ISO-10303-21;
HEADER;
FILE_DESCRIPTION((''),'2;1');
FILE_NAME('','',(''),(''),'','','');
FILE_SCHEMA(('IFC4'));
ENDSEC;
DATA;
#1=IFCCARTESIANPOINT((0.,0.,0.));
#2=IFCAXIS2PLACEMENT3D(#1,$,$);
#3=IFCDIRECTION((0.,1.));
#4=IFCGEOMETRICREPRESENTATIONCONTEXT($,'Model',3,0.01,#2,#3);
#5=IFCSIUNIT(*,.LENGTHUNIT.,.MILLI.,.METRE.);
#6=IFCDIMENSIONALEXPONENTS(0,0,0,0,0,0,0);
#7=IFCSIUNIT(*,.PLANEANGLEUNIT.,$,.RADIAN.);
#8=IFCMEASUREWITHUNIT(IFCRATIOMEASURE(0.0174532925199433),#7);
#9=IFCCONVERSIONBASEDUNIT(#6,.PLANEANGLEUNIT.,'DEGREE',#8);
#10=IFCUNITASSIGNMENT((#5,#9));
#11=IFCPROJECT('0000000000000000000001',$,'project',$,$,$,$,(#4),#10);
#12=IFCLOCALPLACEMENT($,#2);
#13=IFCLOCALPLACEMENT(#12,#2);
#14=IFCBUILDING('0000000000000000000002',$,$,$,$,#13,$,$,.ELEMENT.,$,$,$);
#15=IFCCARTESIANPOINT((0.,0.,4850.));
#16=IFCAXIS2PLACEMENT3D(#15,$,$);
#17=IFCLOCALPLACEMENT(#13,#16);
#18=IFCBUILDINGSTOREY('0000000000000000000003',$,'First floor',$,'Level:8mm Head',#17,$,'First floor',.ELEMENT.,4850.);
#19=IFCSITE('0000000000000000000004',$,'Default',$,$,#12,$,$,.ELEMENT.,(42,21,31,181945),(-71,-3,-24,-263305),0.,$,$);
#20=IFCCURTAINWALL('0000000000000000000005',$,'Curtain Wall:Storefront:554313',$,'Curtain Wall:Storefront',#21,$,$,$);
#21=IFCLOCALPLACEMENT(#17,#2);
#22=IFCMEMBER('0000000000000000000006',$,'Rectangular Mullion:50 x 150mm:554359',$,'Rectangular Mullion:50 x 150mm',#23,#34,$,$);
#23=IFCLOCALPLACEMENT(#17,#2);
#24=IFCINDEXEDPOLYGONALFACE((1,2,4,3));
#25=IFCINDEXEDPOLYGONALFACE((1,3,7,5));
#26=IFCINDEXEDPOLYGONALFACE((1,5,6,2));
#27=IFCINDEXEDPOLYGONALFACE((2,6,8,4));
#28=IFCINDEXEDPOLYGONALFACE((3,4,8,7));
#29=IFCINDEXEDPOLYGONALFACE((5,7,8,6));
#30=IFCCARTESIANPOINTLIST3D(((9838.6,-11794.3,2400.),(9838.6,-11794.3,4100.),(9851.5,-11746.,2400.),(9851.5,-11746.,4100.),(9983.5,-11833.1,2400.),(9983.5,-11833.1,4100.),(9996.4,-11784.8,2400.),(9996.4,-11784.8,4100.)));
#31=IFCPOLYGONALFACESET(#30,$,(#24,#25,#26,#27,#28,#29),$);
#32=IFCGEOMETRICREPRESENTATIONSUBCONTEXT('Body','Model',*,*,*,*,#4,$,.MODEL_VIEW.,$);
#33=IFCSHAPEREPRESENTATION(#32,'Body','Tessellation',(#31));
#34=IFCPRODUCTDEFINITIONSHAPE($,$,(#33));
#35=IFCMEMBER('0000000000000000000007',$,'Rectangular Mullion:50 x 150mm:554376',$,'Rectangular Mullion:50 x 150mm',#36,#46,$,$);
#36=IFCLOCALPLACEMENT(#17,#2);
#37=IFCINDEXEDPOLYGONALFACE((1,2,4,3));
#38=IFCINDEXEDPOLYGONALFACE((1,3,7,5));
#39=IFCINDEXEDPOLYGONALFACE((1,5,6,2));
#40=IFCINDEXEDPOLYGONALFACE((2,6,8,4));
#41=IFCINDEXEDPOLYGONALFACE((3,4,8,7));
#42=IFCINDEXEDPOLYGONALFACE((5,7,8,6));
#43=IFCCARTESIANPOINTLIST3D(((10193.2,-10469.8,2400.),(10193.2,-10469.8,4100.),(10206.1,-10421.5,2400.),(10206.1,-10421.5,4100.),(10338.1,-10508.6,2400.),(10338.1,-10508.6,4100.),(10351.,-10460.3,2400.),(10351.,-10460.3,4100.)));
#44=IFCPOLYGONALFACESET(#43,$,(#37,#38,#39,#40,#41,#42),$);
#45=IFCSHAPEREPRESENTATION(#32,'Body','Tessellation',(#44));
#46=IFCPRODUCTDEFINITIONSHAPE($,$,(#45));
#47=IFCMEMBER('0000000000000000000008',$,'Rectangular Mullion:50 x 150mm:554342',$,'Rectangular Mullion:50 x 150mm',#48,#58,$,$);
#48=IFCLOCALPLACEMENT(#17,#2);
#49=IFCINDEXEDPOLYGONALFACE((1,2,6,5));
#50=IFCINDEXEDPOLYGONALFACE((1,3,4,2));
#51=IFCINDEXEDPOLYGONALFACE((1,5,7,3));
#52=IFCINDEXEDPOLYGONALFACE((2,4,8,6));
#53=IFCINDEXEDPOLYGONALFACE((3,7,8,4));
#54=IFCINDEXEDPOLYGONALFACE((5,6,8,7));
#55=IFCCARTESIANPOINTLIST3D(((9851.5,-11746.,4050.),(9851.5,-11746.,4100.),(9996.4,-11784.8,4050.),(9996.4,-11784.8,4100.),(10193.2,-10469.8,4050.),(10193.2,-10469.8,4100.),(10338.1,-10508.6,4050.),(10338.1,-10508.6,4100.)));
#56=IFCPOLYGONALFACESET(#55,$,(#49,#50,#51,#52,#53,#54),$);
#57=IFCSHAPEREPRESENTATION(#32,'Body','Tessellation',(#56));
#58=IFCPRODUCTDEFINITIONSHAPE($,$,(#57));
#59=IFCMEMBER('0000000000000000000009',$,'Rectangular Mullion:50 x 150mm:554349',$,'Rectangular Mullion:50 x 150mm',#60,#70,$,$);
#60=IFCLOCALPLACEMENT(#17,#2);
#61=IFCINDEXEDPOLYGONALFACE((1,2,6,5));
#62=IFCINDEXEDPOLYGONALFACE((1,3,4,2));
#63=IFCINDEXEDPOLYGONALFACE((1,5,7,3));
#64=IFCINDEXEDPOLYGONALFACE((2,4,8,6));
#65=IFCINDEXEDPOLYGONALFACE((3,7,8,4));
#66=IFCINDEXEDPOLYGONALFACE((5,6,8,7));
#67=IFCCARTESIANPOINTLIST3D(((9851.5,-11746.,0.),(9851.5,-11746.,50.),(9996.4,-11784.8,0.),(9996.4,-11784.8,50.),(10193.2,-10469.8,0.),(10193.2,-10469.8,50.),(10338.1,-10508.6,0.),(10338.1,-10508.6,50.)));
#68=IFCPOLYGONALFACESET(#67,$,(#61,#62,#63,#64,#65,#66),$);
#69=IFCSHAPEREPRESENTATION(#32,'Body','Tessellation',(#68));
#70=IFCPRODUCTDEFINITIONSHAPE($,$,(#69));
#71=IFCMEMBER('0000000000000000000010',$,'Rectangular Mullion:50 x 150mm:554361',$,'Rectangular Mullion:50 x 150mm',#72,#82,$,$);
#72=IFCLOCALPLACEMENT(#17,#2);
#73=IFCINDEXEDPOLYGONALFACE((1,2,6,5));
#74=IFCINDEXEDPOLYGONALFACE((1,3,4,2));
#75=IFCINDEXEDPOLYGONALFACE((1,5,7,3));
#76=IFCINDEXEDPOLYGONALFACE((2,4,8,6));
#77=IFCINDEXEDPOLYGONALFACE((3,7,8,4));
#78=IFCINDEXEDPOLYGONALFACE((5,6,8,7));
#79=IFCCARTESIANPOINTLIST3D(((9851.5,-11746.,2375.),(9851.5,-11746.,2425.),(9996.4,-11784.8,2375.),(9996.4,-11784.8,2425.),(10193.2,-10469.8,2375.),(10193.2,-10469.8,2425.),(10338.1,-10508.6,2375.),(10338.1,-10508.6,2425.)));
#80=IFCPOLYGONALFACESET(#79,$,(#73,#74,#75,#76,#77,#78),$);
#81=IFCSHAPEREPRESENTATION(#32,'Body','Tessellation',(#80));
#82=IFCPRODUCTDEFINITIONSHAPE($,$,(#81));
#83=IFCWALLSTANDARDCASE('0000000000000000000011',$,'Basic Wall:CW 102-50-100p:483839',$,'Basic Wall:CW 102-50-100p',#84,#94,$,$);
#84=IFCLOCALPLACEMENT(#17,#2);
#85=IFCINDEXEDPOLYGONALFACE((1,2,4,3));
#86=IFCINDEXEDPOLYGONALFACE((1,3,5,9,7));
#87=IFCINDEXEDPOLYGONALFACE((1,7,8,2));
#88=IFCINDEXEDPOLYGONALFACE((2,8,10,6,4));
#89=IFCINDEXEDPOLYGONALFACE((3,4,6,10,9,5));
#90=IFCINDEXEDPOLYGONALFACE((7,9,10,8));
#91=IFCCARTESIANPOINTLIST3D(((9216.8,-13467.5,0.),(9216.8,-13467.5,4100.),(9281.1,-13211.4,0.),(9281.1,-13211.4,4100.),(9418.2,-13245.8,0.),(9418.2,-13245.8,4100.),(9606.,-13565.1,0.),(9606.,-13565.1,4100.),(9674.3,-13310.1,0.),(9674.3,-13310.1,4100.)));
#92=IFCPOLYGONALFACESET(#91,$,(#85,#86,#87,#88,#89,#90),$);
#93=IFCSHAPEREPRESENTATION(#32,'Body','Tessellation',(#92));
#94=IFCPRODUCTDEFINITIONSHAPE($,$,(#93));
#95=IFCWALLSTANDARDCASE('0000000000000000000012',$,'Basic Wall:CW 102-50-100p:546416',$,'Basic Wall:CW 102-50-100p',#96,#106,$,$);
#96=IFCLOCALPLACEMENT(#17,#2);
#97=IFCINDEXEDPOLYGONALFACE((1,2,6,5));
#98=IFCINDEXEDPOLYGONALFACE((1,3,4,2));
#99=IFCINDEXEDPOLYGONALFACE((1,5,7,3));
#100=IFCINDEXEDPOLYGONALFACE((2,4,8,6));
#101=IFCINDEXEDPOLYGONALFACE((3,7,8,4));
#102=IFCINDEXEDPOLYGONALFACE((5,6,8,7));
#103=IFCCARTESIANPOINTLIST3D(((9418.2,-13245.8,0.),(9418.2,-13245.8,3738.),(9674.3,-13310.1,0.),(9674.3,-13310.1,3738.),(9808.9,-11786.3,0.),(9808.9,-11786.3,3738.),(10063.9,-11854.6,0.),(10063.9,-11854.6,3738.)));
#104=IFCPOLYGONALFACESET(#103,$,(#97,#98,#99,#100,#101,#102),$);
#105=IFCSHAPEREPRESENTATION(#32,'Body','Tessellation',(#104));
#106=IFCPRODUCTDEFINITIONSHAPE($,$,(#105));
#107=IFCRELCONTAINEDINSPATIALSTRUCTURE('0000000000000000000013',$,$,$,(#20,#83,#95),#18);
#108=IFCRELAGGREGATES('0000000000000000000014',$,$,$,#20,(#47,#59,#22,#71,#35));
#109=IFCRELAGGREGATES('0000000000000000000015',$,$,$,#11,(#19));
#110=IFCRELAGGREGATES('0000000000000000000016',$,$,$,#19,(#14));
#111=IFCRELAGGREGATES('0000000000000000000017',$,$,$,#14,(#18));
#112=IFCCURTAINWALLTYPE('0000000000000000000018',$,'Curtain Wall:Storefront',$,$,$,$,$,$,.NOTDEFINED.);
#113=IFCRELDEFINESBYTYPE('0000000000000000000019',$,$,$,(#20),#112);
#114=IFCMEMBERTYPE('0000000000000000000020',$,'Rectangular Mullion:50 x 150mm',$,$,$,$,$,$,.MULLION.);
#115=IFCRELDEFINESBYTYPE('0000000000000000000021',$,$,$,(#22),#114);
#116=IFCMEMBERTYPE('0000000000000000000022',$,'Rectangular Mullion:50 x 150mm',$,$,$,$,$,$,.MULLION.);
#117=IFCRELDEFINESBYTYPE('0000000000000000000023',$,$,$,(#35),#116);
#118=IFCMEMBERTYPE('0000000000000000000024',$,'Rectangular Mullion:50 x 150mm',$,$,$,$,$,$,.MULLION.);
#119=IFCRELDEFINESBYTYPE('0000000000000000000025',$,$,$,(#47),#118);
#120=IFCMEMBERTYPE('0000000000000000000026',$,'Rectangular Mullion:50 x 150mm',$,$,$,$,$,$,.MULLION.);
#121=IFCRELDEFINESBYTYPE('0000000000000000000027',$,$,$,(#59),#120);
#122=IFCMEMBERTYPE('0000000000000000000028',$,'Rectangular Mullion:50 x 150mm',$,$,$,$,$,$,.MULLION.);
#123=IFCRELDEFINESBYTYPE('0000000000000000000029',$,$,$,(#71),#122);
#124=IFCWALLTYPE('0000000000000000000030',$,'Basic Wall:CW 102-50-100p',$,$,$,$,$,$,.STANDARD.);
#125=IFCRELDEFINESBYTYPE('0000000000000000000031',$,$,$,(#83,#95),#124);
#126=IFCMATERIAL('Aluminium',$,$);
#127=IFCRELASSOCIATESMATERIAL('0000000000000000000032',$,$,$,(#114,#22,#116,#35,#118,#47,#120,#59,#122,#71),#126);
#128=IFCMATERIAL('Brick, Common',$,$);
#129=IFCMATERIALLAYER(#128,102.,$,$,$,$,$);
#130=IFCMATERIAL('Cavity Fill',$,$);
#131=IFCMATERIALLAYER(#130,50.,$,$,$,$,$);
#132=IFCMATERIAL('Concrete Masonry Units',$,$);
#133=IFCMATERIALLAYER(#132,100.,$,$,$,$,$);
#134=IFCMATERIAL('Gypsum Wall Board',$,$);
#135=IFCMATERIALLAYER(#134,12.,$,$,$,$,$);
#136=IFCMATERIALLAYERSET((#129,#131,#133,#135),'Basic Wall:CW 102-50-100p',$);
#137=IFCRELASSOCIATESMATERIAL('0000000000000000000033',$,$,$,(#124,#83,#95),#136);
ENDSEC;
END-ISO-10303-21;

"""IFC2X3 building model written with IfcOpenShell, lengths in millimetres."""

from ifc_helpers import new_model, entity, si_unit, converted_unit, direction, frame, frame_2d, origin, origin_2d_with_axis, place, context, subcontext, project, spatial, polyline, rectangle, outline, extrude, source, transform, mapped, material, layer, layer_set, layer_usage, type_object, type_shapes, element, aggregate, save


model = new_model("IFC2X3")

# Units and contexts
model_context = context("Model", 3, precision=0.01, world=origin(), true_north=direction((0.0, 1.0)))
body_context = subcontext(model_context, "Body", "Model", "MODEL_VIEW")
ifc_project = project(units=[si_unit("LENGTHUNIT", "METRE", prefix="MILLI"), converted_unit("PLANEANGLEUNIT", "DEGREE", entity("IfcRatioMeasure", 0.0174532925199433), si_unit("PLANEANGLEUNIT", "RADIAN"), dimensions=[0, 0, 0, 0, 0, 0, 0])], contexts=[model_context])

# Site, building, storey
site_placement = place(None, origin())
site = spatial("IfcSite", under=ifc_project, at=site_placement, Name="Default", CompositionType="ELEMENT", RefLatitude=(42, 21, 31, 181945), RefLongitude=(-71, -3, -24, -263305), RefElevation=0.0)
building_placement = place(site_placement, origin())
building = spatial("IfcBuilding", under=site, at=building_placement, CompositionType="ELEMENT")
storey_placement = place(building_placement, frame((0.0, 0.0, 4850.0)))
storey = spatial("IfcBuildingStorey", under=building, at=storey_placement, Name="First floor", ObjectType="Level:8mm Head", LongName="First floor", CompositionType="ELEMENT", Elevation=4850.0)

# Shared definitions
curtain_wall_type = type_object("IfcCurtainWallType", Name="Curtain Wall:Storefront", PredefinedType="NOTDEFINED")
ifc_material_1 = material(Name="Aluminium")

# Curtain wall
curtain_wall_1_placement = place(storey_placement, frame((0.0, 0.0, -4850.0)))
curtain_wall_1 = element("IfcCurtainWall", 1, at=curtain_wall_1_placement, inside=storey, type_object=curtain_wall_type, Name="Curtain Wall:Storefront:554313", ObjectType="Curtain Wall:Storefront")

# Members
member_type_1 = type_object("IfcMemberType", Name="Rectangular Mullion:50 x 150mm", PredefinedType="MULLION", material=ifc_material_1)
shared_shape_1 = source(origin(), body_context, "Body", "SweptSolid", [
    extrude(rectangle(XDim=150.0, YDim=50.0, at=origin_2d_with_axis()), frame((-25.0, 0.0, -1700.0), z_axis=(0.0, 0.0, 1.0), x_axis=(0.0, -1.0, 0.0)), (0.0, 0.0, 1.0), 1700.0),
])
type_shapes(member_type_1, [shared_shape_1])
member_1_placement = place(storey_placement, frame((9911.0, -11813.7, 4100.0), z_axis=(0.0, 0.0, 1.0), x_axis=(-0.258607, -0.965983, 0.0)))
member_1 = element("IfcMember", 2, at=member_1_placement, type_object=member_type_1, material=ifc_material_1, Name="Rectangular Mullion:50 x 150mm:554359", ObjectType="Rectangular Mullion:50 x 150mm", context=body_context, shape_type="MappedRepresentation", body=[
    mapped(shared_shape_1, transform((0.0, 0.0, 0.0), scale=1.0)),
])
member_type_2 = type_object("IfcMemberType", Name="Rectangular Mullion:50 x 150mm", PredefinedType="MULLION", material=ifc_material_1)
shared_shape_2 = source(origin(), body_context, "Body", "SweptSolid", [
    extrude(rectangle(XDim=150.0, YDim=50.0, at=origin_2d_with_axis()), frame((0.0, 0.0, -1700.0), z_axis=(0.0, 0.0, 1.0), x_axis=(0.0, -1.0, 0.0)), (0.0, 0.0, 1.0), 1700.0),
])
type_shapes(member_type_2, [shared_shape_2])
member_2_placement = place(storey_placement, frame((10272.1, -10465.1, 2400.0), z_axis=(0.0, 0.0, -1.0), x_axis=(0.258607, 0.965983, 0.0)))
member_2 = element("IfcMember", 3, at=member_2_placement, type_object=member_type_2, material=ifc_material_1, Name="Rectangular Mullion:50 x 150mm:554376", ObjectType="Rectangular Mullion:50 x 150mm", context=body_context, shape_type="MappedRepresentation", body=[
    mapped(shared_shape_2, transform((0.0, 0.0, 0.0), scale=1.0)),
])
member_type_3 = type_object("IfcMemberType", Name="Rectangular Mullion:50 x 150mm", PredefinedType="MULLION", material=ifc_material_1)
shared_shape_3 = source(origin(), body_context, "Body", "SweptSolid", [
    extrude(rectangle(XDim=150.0, YDim=50.0, at=frame_2d((0.0, 0.0), x_axis=(1.0, 0.0))), frame((-25.0, 0.0, -1321.1), z_axis=(0.0, 0.0, 1.0), x_axis=(0.0, -1.0, 0.0)), (0.0, 0.0, 1.0), 1321.1),
])
type_shapes(member_type_3, [shared_shape_3])
member_3_placement = place(storey_placement, frame((10265.6, -10489.2, 4100.0), z_axis=(0.258607, 0.965983, 0.0), x_axis=(0.0, 0.0, 1.0)))
member_3 = element("IfcMember", 4, at=member_3_placement, type_object=member_type_3, material=ifc_material_1, Name="Rectangular Mullion:50 x 150mm:554342", ObjectType="Rectangular Mullion:50 x 150mm", context=body_context, shape_type="MappedRepresentation", body=[
    mapped(shared_shape_3, transform((0.0, 0.0, 0.0), scale=1.0)),
])
member_type_4 = type_object("IfcMemberType", Name="Rectangular Mullion:50 x 150mm", PredefinedType="MULLION", material=ifc_material_1)
shared_shape_4 = source(origin(), body_context, "Body", "SweptSolid", [
    extrude(rectangle(XDim=150.0, YDim=50.0, at=origin_2d_with_axis()), frame((-25.0, 0.0, -1321.1), z_axis=(0.0, 0.0, 1.0), x_axis=(0.0, -1.0, 0.0)), (0.0, 0.0, 1.0), 1321.1),
])
type_shapes(member_type_4, [shared_shape_4])
member_4_placement = place(storey_placement, frame((9924.0, -11765.4, 0.0), z_axis=(-0.258607, -0.965983, 0.0), x_axis=(0.0, 0.0, -1.0)))
member_4 = element("IfcMember", 5, at=member_4_placement, type_object=member_type_4, material=ifc_material_1, Name="Rectangular Mullion:50 x 150mm:554349", ObjectType="Rectangular Mullion:50 x 150mm", context=body_context, shape_type="MappedRepresentation", body=[
    mapped(shared_shape_4, transform((0.0, 0.0, 0.0), scale=1.0)),
])
member_type_5 = type_object("IfcMemberType", Name="Rectangular Mullion:50 x 150mm", PredefinedType="MULLION", material=ifc_material_1)
shared_shape_5 = source(origin(), body_context, "Body", "SweptSolid", [
    extrude(rectangle(XDim=150.0, YDim=50.0, at=origin_2d_with_axis()), frame((0.0, 0.0, -1321.1), z_axis=(0.0, 0.0, 1.0), x_axis=(0.0, -1.0, 0.0)), (0.0, 0.0, 1.0), 1321.1),
])
type_shapes(member_type_5, [shared_shape_5])
member_5_placement = place(storey_placement, frame((10265.6, -10489.2, 2400.0), z_axis=(0.258607, 0.965983, 0.0), x_axis=(0.0, 0.0, 1.0)))
member_5 = element("IfcMember", 6, at=member_5_placement, type_object=member_type_5, material=ifc_material_1, Name="Rectangular Mullion:50 x 150mm:554361", ObjectType="Rectangular Mullion:50 x 150mm", context=body_context, shape_type="MappedRepresentation", body=[
    mapped(shared_shape_5, transform((0.0, 0.0, 0.0), scale=1.0)),
])

aggregate(curtain_wall_1, [member_3, member_4, member_1, member_5, member_2])

# Walls
ifc_material_2 = material(Name="Brick, Common")
ifc_layer_1 = layer(ifc_material_2, 102.0)
ifc_material_3 = material(Name="Cavity Fill")
ifc_layer_2 = layer(ifc_material_3, 50.0)
ifc_material_4 = material(Name="Concrete Masonry Units")
ifc_layer_3 = layer(ifc_material_4, 100.0)
ifc_material_5 = material(Name="Gypsum Wall Board")
ifc_layer_4 = layer(ifc_material_5, 12.0)
ifc_layer_set = layer_set([ifc_layer_1, ifc_layer_2, ifc_layer_3, ifc_layer_4], Name="Basic Wall:CW 102-50-100p")
ifc_layer_usage_1 = layer_usage(ifc_layer_set, "AXIS2", "NEGATIVE", 132.0)
wall_type = type_object("IfcWallType", Name="Basic Wall:CW 102-50-100p", PredefinedType="STANDARD", material=ifc_layer_set)
wall_1_placement = place(storey_placement, frame((9642.2, -13438.1, 0.0), z_axis=(0.0, 0.0, 1.0), x_axis=(-0.96996, 0.243265, 0.0)))
element("IfcWallStandardCase", 7, at=wall_1_placement, inside=storey, type_object=wall_type, material=ifc_layer_usage_1, Name="Basic Wall:CW 102-50-100p:483839", ObjectType="Basic Wall:CW 102-50-100p", context=body_context, shape_type="SweptSolid", body=[
    extrude(outline(polyline([(405.4, -132.0), (405.4, 132.0), (4.2, 132.0), (0.0, -132.0), (264.0, -132.0), (405.4, -132.0)])), origin(), (0.0, 0.0, 1.0), 4100.0),
])
ifc_layer_usage_2 = layer_usage(ifc_layer_set, "AXIS2", "POSITIVE", -132.0)
wall_2_placement = place(storey_placement, frame((9545.7, -13280.0, 0.0), z_axis=(0.0, 0.0, 1.0), x_axis=(0.258607, 0.965983, 0.0)))
element("IfcWallStandardCase", 8, at=wall_2_placement, inside=storey, type_object=wall_type, material=ifc_layer_usage_2, Name="Basic Wall:CW 102-50-100p:546416", ObjectType="Basic Wall:CW 102-50-100p", context=body_context, shape_type="SweptSolid", body=[
    extrude(outline(polyline([(1510.9, -132.0), (1510.9, 132.0), (0.0, 132.0), (4.2, -132.0), (1510.9, -132.0)])), origin(), (0.0, 0.0, 1.0), 3738.0),
])

save(model, "model.ifc")
